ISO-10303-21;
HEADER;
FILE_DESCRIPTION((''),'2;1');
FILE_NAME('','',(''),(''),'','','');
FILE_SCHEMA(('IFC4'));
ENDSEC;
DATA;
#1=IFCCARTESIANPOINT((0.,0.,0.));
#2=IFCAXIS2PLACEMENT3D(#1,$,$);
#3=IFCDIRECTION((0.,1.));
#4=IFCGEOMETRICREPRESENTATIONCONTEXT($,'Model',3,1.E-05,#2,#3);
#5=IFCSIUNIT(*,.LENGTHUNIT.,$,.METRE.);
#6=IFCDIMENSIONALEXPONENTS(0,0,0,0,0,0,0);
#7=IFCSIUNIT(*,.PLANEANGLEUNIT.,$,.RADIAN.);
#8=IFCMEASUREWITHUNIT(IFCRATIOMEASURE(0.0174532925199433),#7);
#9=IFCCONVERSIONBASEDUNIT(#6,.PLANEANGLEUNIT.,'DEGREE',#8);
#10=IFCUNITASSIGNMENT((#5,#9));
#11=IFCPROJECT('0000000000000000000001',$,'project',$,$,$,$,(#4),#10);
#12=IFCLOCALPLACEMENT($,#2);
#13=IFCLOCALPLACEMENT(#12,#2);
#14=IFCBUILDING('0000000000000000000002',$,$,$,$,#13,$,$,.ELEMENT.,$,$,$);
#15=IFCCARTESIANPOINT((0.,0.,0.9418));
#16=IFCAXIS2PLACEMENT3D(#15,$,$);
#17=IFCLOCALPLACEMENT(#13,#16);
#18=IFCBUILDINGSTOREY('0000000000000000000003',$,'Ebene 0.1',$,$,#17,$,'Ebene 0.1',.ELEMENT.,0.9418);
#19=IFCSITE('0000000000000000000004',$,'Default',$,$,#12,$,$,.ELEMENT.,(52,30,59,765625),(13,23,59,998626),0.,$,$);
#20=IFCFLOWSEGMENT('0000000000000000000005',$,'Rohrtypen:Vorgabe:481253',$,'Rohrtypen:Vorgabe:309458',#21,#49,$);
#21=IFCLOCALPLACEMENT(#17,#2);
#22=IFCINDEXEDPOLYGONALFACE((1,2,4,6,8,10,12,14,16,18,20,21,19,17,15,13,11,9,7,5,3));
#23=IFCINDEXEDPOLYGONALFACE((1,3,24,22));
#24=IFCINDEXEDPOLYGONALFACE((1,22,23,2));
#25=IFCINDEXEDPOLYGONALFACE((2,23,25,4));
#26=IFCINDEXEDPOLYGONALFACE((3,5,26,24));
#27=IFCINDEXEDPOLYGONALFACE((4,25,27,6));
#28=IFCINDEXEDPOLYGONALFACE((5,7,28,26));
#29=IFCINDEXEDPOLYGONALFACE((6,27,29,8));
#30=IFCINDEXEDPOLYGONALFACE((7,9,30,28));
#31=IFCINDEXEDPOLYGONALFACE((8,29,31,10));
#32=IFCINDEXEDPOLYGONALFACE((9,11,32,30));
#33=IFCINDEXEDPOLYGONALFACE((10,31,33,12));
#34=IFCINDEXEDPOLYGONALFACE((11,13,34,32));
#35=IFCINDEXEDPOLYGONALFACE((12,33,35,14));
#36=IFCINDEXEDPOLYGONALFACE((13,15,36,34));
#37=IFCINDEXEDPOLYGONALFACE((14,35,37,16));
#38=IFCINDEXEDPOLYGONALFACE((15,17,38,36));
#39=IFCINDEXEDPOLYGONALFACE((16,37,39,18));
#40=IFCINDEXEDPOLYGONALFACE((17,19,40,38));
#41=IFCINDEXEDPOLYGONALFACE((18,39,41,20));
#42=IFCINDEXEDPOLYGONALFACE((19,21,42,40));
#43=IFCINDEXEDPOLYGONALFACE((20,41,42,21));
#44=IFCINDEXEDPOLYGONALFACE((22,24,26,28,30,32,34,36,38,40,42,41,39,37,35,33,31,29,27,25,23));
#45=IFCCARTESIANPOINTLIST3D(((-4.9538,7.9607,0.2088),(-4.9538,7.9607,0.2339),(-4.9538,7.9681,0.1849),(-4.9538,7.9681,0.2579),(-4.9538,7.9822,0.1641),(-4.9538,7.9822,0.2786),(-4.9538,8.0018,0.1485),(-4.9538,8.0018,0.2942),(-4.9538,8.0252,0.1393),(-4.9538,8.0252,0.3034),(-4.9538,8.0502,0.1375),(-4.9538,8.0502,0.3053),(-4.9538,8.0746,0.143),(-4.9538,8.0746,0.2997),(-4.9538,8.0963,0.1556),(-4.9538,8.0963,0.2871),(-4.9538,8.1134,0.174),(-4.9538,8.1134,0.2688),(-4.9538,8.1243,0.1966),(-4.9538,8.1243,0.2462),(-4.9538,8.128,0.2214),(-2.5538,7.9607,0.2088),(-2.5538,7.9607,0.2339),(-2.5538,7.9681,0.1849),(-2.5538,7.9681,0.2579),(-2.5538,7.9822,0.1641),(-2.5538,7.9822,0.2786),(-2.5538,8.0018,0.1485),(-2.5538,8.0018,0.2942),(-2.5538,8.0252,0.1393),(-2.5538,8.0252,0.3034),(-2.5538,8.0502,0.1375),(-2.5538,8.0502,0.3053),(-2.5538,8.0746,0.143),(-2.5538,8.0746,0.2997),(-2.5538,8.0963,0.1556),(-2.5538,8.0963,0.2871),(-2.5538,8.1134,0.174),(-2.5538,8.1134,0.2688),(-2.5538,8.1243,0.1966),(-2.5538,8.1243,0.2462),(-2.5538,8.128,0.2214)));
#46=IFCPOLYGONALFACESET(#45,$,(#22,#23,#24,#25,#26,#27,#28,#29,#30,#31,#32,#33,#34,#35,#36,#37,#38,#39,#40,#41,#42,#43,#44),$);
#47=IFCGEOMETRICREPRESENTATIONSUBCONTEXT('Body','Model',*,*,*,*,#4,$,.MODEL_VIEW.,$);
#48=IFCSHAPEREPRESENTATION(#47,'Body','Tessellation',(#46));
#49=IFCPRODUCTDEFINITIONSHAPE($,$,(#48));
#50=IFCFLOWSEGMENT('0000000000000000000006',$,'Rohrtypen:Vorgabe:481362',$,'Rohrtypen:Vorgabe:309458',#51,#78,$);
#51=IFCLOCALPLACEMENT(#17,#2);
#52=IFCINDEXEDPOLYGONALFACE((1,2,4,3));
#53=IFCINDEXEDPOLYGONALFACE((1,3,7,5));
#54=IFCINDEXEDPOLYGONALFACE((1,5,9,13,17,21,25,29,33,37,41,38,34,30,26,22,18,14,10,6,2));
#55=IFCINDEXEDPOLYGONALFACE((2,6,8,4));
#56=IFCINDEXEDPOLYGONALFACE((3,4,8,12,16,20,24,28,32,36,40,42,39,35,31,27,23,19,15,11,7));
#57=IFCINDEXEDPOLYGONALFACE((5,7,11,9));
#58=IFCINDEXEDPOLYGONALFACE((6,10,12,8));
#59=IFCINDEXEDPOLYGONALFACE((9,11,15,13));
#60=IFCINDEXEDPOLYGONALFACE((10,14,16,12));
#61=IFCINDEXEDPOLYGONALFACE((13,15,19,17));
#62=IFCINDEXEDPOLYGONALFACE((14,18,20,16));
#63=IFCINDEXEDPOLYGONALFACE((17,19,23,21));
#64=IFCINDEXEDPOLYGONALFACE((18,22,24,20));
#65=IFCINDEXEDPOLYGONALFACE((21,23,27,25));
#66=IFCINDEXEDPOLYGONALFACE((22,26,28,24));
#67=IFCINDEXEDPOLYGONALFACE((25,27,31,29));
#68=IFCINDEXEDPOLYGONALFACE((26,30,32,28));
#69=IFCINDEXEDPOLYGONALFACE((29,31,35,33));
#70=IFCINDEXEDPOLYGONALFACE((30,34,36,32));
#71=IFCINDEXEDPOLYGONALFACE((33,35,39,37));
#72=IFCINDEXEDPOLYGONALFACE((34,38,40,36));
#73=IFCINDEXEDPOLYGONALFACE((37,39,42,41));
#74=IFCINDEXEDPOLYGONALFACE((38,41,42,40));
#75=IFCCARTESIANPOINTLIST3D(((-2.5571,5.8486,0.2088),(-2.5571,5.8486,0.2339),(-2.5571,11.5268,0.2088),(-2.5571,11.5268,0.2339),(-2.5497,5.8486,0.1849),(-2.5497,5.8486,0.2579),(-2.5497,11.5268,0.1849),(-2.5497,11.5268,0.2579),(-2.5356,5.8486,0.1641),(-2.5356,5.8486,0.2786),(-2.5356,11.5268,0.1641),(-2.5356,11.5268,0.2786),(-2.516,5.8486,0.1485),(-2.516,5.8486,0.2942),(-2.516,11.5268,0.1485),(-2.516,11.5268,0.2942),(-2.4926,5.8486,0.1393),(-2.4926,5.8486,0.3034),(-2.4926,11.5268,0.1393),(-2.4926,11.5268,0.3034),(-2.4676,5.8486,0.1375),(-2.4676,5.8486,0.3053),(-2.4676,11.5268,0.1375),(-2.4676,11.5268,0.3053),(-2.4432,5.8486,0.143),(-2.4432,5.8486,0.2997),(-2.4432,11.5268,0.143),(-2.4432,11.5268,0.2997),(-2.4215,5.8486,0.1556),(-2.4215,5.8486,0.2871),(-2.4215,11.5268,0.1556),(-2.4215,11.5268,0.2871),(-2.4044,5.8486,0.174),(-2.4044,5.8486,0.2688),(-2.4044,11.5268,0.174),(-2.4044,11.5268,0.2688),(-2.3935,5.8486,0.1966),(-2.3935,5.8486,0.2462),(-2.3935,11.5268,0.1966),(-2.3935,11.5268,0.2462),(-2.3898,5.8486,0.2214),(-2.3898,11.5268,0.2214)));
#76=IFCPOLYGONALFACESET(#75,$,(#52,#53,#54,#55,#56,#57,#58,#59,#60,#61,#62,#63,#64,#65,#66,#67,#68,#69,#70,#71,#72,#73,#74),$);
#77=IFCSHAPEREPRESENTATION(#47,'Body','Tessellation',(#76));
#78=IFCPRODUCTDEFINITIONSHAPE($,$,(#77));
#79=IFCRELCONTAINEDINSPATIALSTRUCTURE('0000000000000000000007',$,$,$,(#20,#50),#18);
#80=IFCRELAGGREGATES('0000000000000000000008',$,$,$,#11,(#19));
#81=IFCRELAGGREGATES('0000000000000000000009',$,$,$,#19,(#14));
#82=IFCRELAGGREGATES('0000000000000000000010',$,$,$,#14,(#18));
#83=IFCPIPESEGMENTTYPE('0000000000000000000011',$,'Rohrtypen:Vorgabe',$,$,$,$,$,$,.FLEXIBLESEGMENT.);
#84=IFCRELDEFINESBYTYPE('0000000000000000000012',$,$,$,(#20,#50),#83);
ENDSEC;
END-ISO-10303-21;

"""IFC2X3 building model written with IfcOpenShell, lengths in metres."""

from ifc_helpers import new_model, entity, si_unit, converted_unit, direction, frame, frame_2d, origin, place, context, subcontext, project, spatial, circle, extrude, type_object, element, save


model = new_model("IFC2X3")

# Units and contexts
model_context = context("Model", 3, precision=1e-05, world=origin(), true_north=direction((0.0, 1.0)))
body_context = subcontext(model_context, "Body", "Model", "MODEL_VIEW")
ifc_project = project(units=[si_unit("LENGTHUNIT", "METRE"), converted_unit("PLANEANGLEUNIT", "DEGREE", entity("IfcRatioMeasure", 0.0174532925199433), si_unit("PLANEANGLEUNIT", "RADIAN"), dimensions=[0, 0, 0, 0, 0, 0, 0])], contexts=[model_context])

# Site, building, storey
site_placement = place(None, origin())
site = spatial("IfcSite", under=ifc_project, at=site_placement, Name="Default", CompositionType="ELEMENT", RefLatitude=(52, 30, 59, 765625), RefLongitude=(13, 23, 59, 998626), RefElevation=0.0)
building_placement = place(site_placement, origin())
building = spatial("IfcBuilding", under=site, at=building_placement, CompositionType="ELEMENT")
storey_placement = place(building_placement, frame((0.0, 0.0, 0.9418)))
storey = spatial("IfcBuildingStorey", under=building, at=storey_placement, Name="Ebene 0.1", LongName="Ebene 0.1", CompositionType="ELEMENT", Elevation=0.9418)

# Flow segments
pipe_segment_type = type_object("IfcPipeSegmentType", Name="Rohrtypen:Vorgabe", PredefinedType="FLEXIBLESEGMENT")
flow_segment_1_placement = place(storey_placement, origin())
element("IfcFlowSegment", 1, at=flow_segment_1_placement, inside=storey, type_object=pipe_segment_type, Name="Rohrtypen:Vorgabe:481253", ObjectType="Rohrtypen:Vorgabe:309458", context=body_context, shape_type="SweptSolid", body=[
    extrude(circle(Radius=0.0841, at=frame_2d((0.0, 0.0), x_axis=(1.0, 0.0))), frame((-4.9538, 8.0439, 0.2214), z_axis=(1.0, 0.0, 0.0), x_axis=(0.0, 1.0, 0.0)), (0.0, 0.0, 1.0), 2.4),
])
flow_segment_2_placement = place(storey_placement, origin())
element("IfcFlowSegment", 2, at=flow_segment_2_placement, inside=storey, type_object=pipe_segment_type, Name="Rohrtypen:Vorgabe:481362", ObjectType="Rohrtypen:Vorgabe:309458", context=body_context, shape_type="SweptSolid", body=[
    extrude(circle(Radius=0.0841, at=frame_2d((0.0, 0.0), x_axis=(1.0, 0.0))), frame((-2.4739, 5.8486, 0.2214), z_axis=(0.0, 1.0, 0.0), x_axis=(1.0, 0.0, 0.0)), (0.0, 0.0, 1.0), 5.6782),
])

save(model, "model.ifc")
